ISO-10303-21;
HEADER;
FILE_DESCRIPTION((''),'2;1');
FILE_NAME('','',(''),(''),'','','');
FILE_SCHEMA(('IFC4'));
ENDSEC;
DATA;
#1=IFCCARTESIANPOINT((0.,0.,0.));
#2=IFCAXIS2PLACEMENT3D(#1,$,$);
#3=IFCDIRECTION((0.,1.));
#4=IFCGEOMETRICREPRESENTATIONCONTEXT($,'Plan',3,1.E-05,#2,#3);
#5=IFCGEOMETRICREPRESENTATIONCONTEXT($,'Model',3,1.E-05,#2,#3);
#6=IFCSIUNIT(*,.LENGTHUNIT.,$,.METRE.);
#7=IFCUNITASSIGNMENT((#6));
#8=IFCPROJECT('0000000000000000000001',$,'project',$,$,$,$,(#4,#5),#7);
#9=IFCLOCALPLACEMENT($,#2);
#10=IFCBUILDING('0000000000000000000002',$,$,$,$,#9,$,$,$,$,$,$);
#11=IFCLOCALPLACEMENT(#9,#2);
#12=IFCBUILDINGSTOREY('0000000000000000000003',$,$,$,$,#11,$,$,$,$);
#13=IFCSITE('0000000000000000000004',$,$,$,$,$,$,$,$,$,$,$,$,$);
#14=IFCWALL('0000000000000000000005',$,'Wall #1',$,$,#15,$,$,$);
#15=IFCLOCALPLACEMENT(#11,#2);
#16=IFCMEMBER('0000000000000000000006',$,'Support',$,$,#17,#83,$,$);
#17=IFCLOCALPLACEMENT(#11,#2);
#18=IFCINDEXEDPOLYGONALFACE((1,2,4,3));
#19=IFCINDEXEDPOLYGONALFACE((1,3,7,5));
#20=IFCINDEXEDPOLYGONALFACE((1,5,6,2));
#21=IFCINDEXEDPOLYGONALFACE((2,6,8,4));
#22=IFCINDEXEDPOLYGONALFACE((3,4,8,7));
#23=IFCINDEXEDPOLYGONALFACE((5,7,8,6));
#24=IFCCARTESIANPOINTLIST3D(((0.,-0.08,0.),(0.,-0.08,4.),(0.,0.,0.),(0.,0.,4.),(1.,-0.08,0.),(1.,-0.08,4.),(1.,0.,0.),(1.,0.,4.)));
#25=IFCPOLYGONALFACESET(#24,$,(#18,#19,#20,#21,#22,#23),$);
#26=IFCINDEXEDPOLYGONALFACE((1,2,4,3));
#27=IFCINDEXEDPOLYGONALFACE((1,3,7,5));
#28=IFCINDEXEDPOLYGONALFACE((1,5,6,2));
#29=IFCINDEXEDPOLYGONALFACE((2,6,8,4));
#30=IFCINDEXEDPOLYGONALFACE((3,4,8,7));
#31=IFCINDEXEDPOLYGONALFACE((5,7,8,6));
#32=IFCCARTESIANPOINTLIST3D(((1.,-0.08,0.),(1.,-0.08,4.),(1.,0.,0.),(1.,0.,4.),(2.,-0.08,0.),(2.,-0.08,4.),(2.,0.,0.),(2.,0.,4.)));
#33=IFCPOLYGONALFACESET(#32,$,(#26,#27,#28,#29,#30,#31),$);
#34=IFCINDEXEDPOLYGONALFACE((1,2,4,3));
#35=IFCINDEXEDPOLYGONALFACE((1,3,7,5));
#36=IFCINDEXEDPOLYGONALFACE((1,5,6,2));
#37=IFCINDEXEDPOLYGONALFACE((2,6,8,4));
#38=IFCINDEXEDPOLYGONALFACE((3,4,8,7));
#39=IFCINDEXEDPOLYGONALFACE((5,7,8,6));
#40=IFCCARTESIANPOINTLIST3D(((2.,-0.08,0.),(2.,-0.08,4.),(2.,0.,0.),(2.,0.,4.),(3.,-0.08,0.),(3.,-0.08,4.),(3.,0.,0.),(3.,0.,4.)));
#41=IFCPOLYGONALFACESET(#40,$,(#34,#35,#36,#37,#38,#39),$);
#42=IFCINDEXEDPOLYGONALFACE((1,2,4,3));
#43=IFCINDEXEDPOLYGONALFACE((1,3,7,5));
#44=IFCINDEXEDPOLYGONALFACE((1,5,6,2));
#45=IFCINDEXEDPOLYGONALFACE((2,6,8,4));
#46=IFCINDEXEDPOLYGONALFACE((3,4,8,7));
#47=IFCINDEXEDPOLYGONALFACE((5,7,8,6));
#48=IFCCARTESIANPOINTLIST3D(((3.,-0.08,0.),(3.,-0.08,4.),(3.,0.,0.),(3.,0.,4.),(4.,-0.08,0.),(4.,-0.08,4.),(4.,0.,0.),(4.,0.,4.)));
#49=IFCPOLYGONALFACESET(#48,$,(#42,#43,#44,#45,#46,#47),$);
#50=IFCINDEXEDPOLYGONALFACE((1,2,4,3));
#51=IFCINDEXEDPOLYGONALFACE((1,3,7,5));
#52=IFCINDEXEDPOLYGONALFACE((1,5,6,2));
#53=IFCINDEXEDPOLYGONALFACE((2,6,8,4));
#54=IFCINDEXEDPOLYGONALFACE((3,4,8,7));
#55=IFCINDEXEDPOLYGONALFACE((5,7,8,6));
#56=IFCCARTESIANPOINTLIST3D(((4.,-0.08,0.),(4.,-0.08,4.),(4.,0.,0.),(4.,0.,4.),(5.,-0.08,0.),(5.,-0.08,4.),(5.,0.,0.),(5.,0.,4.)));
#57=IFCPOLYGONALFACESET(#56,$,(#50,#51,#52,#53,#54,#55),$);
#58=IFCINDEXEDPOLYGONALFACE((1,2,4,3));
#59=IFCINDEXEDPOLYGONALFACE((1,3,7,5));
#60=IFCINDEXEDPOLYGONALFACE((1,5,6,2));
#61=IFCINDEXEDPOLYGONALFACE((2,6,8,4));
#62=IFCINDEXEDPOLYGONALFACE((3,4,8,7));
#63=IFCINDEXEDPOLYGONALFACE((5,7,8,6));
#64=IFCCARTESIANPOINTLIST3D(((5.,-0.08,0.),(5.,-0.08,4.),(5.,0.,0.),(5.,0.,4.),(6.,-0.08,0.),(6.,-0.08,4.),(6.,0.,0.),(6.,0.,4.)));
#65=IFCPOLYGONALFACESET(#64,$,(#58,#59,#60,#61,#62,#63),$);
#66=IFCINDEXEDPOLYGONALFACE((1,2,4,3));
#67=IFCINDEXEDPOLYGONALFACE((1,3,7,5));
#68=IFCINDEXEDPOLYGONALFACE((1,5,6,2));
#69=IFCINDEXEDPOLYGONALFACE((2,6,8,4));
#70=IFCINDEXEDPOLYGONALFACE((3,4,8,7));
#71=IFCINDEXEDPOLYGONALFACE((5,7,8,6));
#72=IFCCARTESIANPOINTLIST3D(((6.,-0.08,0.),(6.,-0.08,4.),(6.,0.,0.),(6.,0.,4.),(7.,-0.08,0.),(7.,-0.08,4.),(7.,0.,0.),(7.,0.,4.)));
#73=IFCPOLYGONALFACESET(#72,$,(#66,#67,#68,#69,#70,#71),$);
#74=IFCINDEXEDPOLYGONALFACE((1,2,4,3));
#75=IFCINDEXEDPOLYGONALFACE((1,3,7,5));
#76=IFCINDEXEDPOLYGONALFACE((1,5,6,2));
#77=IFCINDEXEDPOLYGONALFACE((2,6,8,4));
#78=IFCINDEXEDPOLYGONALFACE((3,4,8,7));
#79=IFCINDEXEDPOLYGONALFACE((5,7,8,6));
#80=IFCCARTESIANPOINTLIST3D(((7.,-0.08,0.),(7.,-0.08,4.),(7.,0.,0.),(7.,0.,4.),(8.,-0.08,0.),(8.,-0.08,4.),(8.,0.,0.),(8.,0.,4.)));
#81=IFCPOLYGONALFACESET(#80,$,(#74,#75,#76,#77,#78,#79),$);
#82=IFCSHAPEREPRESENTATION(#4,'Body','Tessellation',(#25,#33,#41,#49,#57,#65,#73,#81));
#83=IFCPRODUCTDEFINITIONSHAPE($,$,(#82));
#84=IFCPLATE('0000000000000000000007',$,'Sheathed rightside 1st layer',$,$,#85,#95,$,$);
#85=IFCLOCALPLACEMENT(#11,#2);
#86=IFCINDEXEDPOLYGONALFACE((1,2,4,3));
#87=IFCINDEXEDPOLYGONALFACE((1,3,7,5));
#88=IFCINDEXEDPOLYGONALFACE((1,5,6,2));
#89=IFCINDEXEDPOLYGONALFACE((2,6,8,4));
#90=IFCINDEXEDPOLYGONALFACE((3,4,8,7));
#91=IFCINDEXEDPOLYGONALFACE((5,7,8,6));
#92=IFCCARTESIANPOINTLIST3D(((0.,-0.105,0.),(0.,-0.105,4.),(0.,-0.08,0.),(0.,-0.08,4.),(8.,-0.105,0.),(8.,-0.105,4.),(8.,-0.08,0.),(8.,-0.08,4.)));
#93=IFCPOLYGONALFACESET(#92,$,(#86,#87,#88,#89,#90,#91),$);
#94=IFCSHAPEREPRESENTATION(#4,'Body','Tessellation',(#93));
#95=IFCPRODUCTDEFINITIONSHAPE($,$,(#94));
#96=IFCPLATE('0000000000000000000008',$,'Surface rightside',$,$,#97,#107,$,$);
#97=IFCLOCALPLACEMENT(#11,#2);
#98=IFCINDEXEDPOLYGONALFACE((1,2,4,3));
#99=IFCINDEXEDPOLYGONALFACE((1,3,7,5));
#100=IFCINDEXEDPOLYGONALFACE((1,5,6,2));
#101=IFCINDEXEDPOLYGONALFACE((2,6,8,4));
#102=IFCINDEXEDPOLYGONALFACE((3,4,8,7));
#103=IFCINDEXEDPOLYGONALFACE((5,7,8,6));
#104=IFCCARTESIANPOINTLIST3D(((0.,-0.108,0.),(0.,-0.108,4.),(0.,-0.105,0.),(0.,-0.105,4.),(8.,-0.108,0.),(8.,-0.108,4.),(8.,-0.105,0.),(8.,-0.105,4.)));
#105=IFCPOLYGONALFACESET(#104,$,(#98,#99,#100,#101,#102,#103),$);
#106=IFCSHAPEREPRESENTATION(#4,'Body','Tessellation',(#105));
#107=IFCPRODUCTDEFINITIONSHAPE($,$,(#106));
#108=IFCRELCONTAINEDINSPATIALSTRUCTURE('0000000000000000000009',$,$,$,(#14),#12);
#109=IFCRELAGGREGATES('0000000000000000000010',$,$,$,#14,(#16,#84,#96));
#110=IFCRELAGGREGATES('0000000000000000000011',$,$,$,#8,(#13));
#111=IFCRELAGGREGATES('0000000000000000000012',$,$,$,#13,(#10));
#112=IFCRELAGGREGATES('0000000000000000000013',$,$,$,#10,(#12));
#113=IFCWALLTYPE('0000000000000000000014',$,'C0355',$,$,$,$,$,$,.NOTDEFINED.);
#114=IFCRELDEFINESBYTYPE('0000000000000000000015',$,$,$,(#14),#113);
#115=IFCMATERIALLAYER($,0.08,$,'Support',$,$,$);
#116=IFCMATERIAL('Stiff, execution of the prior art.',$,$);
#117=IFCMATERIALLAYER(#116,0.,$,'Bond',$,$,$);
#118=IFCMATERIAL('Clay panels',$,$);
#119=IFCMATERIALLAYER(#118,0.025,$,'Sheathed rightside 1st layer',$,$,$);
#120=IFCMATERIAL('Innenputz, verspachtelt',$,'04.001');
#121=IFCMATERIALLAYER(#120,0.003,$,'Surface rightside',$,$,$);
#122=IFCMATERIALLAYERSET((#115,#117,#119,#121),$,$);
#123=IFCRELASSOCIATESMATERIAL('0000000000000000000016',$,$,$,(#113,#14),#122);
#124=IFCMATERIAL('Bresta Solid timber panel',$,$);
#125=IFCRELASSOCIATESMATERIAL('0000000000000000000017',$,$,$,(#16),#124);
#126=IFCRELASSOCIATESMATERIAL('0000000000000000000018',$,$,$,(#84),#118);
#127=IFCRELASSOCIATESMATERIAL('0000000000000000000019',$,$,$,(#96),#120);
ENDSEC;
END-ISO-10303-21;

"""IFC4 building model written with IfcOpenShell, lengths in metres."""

from ifc_helpers import new_model, si_unit, direction, frame, frame_2d, origin, place, context, project, spatial, rectangle, extrude, material, layer, layer_set, type_object, element, aggregate, save


model = new_model("IFC4")

# Units and contexts
plan_context = context("Plan", 3, precision=1e-05, world=origin(), true_north=direction((0.0, 1.0)))
model_context = context("Model", 3, precision=1e-05, world=origin(), true_north=direction((0.0, 1.0)))
ifc_project = project(units=[si_unit("LENGTHUNIT", "METRE")], contexts=[plan_context, model_context])

# Site, building, storey
site = spatial("IfcSite", under=ifc_project)
building_placement = place(None, origin())
building = spatial("IfcBuilding", under=site, at=building_placement)
storey_placement = place(building_placement, origin())
storey = spatial("IfcBuildingStorey", under=building, at=storey_placement)

# Wall, member, plates
ifc_layer_1 = layer(None, 0.08, Name="Support")
ifc_material_1 = material(Name="Stiff, execution of the prior art.")
ifc_layer_2 = layer(ifc_material_1, 0.0, Name="Bond")
ifc_material_2 = material(Name="Clay panels")
ifc_layer_3 = layer(ifc_material_2, 0.025, Name="Sheathed rightside 1st layer")
ifc_material_3 = material(Name="Innenputz, verspachtelt", Category="04.001")
ifc_layer_4 = layer(ifc_material_3, 0.003, Name="Surface rightside")
ifc_layer_set = layer_set([ifc_layer_1, ifc_layer_2, ifc_layer_3, ifc_layer_4])
wall_type = type_object("IfcWallType", Name="C0355", PredefinedType="NOTDEFINED", material=ifc_layer_set)
wall_placement = place(None, frame((0.0, 0.0, 0.0), z_axis=(0.0, -1.0, 0.0), x_axis=(1.0, 0.0, 0.0)))
wall = element("IfcWall", 1, at=wall_placement, inside=storey, type_object=wall_type, material=ifc_layer_set, Name="Wall #1")
ifc_material_4 = material(Name="Bresta Solid timber panel")
member_placement = place(wall_placement, origin())
member = element("IfcMember", 2, at=member_placement, material=ifc_material_4, Name="Support", context=plan_context, shape_type="SweptSolid", body=[
    extrude(rectangle(XDim=1.0, YDim=0.08, at=frame_2d((0.5, 0.04), x_axis=(1.0, 0.0))), frame((0.0, 4.0, 0.0), z_axis=(0.0, -1.0, 0.0), x_axis=(1.0, 0.0, 0.0)), (0.0, 0.0, 1.0), 4.0),
    extrude(rectangle(XDim=1.0, YDim=0.08, at=frame_2d((0.5, 0.04), x_axis=(1.0, 0.0))), frame((1.0, 4.0, 0.0), z_axis=(0.0, -1.0, 0.0), x_axis=(1.0, 0.0, 0.0)), (0.0, 0.0, 1.0), 4.0),
    extrude(rectangle(XDim=1.0, YDim=0.08, at=frame_2d((0.5, 0.04), x_axis=(1.0, 0.0))), frame((2.0, 4.0, 0.0), z_axis=(0.0, -1.0, 0.0), x_axis=(1.0, 0.0, 0.0)), (0.0, 0.0, 1.0), 4.0),
    extrude(rectangle(XDim=1.0, YDim=0.08, at=frame_2d((0.5, 0.04), x_axis=(1.0, 0.0))), frame((3.0, 4.0, 0.0), z_axis=(0.0, -1.0, 0.0), x_axis=(1.0, 0.0, 0.0)), (0.0, 0.0, 1.0), 4.0),
    extrude(rectangle(XDim=1.0, YDim=0.08, at=frame_2d((0.5, 0.04), x_axis=(1.0, 0.0))), frame((4.0, 4.0, 0.0), z_axis=(0.0, -1.0, 0.0), x_axis=(1.0, 0.0, 0.0)), (0.0, 0.0, 1.0), 4.0),
    extrude(rectangle(XDim=1.0, YDim=0.08, at=frame_2d((0.5, 0.04), x_axis=(1.0, 0.0))), frame((5.0, 4.0, 0.0), z_axis=(0.0, -1.0, 0.0), x_axis=(1.0, 0.0, 0.0)), (0.0, 0.0, 1.0), 4.0),
    extrude(rectangle(XDim=1.0, YDim=0.08, at=frame_2d((0.5, 0.04), x_axis=(1.0, 0.0))), frame((6.0, 4.0, 0.0), z_axis=(0.0, -1.0, 0.0), x_axis=(1.0, 0.0, 0.0)), (0.0, 0.0, 1.0), 4.0),
    extrude(rectangle(XDim=1.0, YDim=0.08, at=frame_2d((0.5, 0.04), x_axis=(1.0, 0.0))), frame((7.0, 4.0, 0.0), z_axis=(0.0, -1.0, 0.0), x_axis=(1.0, 0.0, 0.0)), (0.0, 0.0, 1.0), 4.0),
])
plate_1_placement = place(wall_placement, origin())
plate_1 = element("IfcPlate", 3, at=plate_1_placement, material=ifc_material_2, Name="Sheathed rightside 1st layer", context=plan_context, shape_type="SweptSolid", body=[
    extrude(rectangle(XDim=8.0, YDim=4.0, at=frame_2d((4.0, 2.0), x_axis=(1.0, 0.0))), frame((0.0, 0.0, 0.08), z_axis=(0.0, 0.0, 1.0), x_axis=(1.0, 0.0, 0.0)), (0.0, 0.0, 1.0), 0.025),
])
plate_2_placement = place(wall_placement, origin())
plate_2 = element("IfcPlate", 4, at=plate_2_placement, material=ifc_material_3, Name="Surface rightside", context=plan_context, shape_type="SweptSolid", body=[
    extrude(rectangle(XDim=8.0, YDim=4.0, at=frame_2d((4.0, 2.0), x_axis=(1.0, 0.0))), frame((0.0, 0.0, 0.105), z_axis=(0.0, 0.0, 1.0), x_axis=(1.0, 0.0, 0.0)), (0.0, 0.0, 1.0), 0.003),
])
aggregate(wall, [member, plate_1, plate_2])

save(model, "model.ifc")
